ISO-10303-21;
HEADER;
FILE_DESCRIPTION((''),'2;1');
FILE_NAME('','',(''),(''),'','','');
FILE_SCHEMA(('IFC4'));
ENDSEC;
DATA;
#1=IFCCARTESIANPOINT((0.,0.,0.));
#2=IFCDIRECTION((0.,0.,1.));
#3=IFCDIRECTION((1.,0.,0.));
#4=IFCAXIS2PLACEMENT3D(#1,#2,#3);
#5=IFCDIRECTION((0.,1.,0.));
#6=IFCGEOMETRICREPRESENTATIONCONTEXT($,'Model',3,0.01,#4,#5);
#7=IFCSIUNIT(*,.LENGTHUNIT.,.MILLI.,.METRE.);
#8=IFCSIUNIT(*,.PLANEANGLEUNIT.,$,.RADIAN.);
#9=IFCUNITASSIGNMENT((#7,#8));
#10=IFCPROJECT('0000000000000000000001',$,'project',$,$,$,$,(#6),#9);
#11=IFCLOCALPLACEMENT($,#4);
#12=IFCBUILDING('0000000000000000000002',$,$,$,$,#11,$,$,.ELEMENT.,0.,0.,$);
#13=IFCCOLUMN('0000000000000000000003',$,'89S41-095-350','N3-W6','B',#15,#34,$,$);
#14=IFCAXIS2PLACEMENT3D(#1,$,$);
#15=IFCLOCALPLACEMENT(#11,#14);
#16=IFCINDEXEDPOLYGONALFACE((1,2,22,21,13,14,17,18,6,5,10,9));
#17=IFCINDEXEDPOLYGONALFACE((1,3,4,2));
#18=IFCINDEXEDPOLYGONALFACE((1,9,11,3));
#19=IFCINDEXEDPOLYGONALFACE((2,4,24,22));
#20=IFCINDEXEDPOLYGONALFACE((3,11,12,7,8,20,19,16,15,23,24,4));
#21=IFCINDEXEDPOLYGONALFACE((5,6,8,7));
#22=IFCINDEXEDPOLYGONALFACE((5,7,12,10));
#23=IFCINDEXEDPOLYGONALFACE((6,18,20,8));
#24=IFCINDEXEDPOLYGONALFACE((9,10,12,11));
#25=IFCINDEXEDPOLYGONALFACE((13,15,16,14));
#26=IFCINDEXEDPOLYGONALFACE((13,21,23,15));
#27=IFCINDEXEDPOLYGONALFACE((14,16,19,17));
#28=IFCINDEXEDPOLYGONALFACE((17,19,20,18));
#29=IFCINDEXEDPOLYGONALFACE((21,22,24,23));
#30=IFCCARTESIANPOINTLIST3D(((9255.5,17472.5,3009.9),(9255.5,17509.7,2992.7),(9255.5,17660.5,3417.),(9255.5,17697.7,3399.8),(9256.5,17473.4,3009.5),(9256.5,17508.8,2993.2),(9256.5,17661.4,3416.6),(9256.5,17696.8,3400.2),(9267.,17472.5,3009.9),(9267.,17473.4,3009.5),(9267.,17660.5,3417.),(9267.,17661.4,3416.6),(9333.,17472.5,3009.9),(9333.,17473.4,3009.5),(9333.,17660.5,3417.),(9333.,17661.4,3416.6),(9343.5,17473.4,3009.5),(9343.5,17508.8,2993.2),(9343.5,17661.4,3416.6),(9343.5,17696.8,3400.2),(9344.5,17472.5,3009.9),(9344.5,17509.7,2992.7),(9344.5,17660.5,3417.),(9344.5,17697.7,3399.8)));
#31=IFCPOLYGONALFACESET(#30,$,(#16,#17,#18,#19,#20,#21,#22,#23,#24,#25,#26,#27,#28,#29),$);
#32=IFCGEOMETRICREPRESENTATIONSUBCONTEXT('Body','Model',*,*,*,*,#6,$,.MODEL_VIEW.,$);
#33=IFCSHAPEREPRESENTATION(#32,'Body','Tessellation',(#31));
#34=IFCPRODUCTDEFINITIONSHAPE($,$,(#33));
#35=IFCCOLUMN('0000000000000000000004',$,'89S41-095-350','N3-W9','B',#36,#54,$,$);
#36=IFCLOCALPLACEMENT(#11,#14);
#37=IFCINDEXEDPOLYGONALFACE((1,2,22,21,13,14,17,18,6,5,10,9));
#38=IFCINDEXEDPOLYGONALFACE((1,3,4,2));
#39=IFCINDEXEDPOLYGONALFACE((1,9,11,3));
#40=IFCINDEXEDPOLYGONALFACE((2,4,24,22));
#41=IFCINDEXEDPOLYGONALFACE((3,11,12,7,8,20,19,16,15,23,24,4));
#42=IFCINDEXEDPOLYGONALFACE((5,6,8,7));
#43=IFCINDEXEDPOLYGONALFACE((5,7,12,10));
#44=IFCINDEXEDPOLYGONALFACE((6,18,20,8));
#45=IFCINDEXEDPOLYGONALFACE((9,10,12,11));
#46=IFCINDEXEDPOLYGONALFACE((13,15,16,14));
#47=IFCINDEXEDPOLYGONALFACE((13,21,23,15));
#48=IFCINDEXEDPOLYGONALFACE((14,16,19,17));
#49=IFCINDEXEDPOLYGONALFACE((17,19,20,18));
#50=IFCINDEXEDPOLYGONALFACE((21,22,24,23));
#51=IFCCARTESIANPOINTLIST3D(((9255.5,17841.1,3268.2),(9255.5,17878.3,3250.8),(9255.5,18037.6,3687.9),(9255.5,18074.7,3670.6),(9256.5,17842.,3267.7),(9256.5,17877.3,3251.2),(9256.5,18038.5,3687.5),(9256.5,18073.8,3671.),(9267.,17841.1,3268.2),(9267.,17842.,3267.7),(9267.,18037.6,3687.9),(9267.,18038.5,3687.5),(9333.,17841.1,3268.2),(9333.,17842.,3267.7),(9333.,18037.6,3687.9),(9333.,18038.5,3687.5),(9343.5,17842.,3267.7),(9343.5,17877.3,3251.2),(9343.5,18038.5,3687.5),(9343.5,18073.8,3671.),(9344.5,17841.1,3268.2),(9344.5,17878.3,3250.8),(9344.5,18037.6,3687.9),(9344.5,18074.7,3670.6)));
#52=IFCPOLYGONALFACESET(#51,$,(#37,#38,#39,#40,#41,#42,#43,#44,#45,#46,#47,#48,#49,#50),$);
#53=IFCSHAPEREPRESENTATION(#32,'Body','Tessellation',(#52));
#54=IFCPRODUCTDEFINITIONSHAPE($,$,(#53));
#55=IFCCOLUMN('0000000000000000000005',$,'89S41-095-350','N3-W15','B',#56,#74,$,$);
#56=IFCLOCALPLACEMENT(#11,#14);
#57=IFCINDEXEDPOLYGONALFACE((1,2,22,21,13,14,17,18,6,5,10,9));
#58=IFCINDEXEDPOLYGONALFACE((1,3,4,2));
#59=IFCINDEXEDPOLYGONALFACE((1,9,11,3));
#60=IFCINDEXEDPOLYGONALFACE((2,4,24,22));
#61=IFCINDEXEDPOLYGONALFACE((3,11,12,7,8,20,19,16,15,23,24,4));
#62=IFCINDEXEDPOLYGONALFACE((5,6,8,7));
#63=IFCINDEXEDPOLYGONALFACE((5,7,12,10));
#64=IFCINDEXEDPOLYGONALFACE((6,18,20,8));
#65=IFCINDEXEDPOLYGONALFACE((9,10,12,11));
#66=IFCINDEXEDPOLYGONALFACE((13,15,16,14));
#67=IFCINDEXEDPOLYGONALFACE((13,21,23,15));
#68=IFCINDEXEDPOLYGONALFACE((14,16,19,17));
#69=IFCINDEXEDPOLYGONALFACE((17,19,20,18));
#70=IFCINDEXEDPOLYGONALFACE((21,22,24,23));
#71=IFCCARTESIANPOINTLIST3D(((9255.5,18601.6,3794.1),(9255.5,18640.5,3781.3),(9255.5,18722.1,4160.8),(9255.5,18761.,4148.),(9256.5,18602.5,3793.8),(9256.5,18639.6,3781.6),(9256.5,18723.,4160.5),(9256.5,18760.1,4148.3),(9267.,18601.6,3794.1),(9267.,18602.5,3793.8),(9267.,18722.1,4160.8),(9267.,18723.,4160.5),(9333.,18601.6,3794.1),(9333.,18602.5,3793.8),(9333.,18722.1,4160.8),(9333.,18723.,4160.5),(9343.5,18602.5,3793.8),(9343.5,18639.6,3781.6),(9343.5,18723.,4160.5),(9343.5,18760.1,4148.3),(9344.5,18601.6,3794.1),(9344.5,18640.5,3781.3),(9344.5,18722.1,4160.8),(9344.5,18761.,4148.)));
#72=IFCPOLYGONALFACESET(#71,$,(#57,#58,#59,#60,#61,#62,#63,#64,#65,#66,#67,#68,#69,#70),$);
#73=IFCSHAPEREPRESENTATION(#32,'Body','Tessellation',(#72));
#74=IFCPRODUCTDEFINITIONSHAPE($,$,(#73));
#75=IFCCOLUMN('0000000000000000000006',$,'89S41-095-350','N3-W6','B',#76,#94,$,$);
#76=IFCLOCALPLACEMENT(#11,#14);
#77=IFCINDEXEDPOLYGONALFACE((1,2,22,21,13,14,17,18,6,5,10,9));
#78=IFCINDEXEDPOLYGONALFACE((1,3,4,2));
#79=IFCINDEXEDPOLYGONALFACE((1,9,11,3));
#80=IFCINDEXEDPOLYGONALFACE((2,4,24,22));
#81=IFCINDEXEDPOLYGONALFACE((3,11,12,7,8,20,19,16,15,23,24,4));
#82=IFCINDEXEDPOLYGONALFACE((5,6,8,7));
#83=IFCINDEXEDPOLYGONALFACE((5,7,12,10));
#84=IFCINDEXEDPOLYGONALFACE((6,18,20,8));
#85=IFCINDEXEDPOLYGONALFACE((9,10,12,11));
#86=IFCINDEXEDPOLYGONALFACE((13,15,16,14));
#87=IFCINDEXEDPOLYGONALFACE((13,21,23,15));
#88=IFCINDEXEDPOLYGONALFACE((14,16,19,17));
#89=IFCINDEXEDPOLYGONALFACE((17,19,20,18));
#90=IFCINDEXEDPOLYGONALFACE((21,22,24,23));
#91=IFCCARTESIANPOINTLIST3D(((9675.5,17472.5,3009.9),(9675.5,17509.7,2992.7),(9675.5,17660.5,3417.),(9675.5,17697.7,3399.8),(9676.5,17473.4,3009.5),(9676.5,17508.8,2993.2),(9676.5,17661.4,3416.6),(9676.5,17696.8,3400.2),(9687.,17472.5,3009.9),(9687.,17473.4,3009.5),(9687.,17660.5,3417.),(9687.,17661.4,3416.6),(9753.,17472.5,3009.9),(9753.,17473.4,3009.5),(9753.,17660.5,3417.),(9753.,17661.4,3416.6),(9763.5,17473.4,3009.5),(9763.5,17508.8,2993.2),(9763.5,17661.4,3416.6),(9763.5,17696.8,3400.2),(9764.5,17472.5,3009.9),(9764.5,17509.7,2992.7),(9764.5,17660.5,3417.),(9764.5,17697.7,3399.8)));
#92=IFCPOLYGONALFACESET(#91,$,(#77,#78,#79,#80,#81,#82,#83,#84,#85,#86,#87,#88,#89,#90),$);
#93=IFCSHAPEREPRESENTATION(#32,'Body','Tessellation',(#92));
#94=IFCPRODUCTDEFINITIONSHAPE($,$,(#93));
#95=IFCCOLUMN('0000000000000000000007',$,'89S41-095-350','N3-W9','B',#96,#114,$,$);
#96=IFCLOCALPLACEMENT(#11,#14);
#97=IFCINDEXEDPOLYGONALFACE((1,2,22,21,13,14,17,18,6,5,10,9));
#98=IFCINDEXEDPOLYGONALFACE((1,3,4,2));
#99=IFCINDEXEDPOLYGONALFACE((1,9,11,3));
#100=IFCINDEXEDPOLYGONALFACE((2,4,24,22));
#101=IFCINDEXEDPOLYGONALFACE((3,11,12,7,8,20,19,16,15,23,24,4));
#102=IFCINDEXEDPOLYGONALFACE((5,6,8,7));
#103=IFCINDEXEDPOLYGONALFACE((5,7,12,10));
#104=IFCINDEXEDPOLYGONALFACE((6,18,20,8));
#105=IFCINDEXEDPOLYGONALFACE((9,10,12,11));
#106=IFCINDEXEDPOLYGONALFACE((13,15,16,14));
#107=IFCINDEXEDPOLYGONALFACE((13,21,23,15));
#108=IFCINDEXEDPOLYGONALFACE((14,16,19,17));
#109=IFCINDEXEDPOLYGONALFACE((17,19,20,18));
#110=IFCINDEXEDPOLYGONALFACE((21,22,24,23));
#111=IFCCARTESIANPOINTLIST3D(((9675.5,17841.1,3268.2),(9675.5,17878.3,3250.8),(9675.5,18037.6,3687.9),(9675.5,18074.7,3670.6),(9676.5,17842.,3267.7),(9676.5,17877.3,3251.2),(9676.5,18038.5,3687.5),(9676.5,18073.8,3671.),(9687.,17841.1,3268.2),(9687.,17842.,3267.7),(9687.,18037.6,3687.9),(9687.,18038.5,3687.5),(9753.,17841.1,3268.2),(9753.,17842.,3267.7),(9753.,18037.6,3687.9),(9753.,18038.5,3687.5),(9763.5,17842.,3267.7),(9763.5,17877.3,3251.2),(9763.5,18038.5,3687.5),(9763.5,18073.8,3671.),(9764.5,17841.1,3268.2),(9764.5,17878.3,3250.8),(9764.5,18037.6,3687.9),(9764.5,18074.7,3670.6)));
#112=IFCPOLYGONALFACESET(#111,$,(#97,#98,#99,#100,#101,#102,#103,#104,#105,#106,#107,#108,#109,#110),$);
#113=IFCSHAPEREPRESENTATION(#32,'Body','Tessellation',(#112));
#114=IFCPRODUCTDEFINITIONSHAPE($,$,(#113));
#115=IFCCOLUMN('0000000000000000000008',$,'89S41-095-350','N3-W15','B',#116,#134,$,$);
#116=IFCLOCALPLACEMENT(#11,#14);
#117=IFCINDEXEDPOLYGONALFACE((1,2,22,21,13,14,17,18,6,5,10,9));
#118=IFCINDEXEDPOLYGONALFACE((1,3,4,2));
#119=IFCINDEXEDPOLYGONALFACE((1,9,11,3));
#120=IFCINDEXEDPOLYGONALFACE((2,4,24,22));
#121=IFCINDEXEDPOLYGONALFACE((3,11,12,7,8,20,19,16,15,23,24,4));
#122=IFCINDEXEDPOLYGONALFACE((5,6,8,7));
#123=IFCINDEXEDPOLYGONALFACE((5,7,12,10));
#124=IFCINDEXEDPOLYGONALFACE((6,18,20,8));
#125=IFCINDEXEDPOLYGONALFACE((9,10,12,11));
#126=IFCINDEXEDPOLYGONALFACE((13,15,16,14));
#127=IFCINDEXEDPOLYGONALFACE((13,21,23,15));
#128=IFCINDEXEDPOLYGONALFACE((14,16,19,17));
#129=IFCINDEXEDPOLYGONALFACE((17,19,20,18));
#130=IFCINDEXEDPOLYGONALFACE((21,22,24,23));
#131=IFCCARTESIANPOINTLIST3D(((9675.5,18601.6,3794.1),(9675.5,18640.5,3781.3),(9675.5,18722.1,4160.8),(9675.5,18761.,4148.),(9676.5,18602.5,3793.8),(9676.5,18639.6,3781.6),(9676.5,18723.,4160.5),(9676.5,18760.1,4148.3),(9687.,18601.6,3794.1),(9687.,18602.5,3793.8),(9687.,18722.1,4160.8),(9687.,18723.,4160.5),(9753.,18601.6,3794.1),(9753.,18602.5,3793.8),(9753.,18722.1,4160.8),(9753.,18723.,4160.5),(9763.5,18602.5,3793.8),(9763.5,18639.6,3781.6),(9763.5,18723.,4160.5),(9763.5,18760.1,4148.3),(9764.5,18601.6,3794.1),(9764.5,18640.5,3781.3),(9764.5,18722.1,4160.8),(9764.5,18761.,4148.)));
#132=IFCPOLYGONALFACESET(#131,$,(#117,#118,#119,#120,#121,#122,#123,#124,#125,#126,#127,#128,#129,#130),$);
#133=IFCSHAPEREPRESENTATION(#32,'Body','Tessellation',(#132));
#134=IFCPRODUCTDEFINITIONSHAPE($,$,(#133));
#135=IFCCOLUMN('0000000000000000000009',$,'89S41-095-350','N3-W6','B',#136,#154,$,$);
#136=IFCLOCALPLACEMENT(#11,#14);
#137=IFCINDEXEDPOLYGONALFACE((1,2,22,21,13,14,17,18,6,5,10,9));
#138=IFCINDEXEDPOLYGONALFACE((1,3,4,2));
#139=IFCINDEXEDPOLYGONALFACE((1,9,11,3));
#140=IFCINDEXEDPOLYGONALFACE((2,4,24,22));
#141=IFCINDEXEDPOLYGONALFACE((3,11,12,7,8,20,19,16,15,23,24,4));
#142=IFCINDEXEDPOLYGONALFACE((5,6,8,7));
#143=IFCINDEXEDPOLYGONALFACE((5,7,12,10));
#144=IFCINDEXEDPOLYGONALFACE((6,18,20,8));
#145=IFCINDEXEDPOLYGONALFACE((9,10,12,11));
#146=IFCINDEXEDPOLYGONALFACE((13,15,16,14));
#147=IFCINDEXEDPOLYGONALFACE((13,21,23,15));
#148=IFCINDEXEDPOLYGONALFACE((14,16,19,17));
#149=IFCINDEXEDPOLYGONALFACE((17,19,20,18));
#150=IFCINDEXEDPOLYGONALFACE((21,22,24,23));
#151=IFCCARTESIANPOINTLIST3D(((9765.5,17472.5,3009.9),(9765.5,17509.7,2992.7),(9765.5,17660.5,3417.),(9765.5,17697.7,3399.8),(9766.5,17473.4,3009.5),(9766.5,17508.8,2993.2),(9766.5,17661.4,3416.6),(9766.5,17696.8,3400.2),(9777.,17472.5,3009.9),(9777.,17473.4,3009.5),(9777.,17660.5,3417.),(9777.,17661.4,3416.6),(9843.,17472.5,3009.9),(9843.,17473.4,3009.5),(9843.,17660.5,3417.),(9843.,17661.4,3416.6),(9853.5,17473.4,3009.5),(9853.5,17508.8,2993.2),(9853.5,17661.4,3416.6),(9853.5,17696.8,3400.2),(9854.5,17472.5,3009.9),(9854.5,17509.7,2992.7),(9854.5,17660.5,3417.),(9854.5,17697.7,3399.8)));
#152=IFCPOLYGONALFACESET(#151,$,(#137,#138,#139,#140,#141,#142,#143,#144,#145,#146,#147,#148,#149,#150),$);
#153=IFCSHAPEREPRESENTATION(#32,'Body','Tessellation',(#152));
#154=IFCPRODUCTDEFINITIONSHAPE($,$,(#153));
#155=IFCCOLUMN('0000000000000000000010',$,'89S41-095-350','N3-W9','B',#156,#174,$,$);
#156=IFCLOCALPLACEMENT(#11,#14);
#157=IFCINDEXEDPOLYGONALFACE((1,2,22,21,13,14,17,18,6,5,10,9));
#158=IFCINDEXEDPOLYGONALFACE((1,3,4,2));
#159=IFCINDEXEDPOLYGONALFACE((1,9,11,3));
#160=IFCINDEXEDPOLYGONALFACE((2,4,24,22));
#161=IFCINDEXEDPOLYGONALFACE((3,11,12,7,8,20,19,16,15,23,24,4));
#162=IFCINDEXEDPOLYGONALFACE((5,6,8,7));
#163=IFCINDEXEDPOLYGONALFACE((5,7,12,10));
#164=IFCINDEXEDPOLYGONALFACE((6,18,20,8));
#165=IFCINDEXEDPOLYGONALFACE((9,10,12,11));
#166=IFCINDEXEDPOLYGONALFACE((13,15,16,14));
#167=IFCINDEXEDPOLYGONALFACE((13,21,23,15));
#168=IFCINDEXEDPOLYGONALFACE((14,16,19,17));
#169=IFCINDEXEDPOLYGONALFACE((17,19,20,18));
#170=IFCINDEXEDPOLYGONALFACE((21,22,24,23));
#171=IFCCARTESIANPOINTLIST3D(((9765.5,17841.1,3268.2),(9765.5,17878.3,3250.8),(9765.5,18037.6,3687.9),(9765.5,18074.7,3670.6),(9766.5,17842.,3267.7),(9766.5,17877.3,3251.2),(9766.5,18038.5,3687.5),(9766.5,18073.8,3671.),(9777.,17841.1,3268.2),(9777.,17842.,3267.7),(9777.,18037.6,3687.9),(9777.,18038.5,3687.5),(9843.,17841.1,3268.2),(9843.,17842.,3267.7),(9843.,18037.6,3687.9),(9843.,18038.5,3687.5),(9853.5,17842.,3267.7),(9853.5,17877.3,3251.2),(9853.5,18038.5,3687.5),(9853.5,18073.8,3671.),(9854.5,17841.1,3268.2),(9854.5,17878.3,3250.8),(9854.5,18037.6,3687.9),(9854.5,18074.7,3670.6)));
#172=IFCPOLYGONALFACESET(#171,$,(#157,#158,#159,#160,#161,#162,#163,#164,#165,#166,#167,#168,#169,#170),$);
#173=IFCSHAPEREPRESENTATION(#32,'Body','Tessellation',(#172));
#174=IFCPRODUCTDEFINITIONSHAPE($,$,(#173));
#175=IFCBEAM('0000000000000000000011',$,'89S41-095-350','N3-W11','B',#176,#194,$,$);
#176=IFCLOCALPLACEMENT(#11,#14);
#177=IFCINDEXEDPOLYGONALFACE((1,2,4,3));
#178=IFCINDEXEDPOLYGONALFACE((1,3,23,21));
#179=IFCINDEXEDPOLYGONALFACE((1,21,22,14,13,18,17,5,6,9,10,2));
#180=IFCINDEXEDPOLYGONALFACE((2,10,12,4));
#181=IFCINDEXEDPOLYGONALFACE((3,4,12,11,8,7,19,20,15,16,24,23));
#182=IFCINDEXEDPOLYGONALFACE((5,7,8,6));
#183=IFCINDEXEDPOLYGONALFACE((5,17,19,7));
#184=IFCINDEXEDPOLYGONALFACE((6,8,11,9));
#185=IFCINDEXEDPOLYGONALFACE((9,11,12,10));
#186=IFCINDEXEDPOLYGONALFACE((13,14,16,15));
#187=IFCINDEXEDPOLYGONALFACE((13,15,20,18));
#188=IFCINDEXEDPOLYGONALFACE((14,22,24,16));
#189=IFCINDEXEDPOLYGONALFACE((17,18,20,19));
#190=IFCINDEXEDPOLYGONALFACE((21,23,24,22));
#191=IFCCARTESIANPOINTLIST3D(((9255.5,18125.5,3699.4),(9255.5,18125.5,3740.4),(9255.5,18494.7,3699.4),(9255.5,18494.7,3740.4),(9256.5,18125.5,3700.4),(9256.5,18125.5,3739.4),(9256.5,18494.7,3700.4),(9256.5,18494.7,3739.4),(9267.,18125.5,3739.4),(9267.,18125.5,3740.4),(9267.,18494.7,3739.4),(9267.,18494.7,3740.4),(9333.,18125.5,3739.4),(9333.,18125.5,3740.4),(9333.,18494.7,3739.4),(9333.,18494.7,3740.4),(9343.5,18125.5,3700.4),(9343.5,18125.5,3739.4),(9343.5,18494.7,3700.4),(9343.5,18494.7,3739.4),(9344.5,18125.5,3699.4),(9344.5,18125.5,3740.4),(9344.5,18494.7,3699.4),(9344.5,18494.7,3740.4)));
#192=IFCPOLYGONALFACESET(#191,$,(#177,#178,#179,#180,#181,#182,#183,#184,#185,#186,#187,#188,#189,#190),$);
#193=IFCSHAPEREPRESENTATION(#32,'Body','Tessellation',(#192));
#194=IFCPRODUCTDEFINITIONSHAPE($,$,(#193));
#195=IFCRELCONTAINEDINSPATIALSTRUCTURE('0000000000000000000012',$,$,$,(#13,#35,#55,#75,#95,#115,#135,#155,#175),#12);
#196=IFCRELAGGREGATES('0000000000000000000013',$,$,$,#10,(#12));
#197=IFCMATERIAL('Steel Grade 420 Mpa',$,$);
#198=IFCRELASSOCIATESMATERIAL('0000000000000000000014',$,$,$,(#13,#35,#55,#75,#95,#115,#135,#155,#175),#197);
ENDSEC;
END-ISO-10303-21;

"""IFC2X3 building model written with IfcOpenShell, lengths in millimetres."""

from ifc_helpers import new_model, si_unit, direction, frame, origin, origin_with_axes, origin_2d_with_axis, place, context, subcontext, project, spatial, c_section, extrude, source, transform, mapped, material, element, save


model = new_model("IFC2X3")

# Units and contexts
model_context = context("Model", 3, precision=0.01, world=origin_with_axes(), true_north=direction((0.0, 1.0, 0.0)))
body_context = subcontext(model_context, "Body", "Model", "MODEL_VIEW")
ifc_project = project(units=[si_unit("LENGTHUNIT", "METRE", prefix="MILLI"), si_unit("PLANEANGLEUNIT", "RADIAN")], contexts=[model_context])

# Building
building_placement = place(None, origin_with_axes())
building = spatial("IfcBuilding", under=ifc_project, at=building_placement, CompositionType="ELEMENT", ElevationOfRefHeight=0.0, ElevationOfTerrain=0.0)

# Columns
ifc_material = material(Name="Steel Grade 420 Mpa")
shared_shape_1 = source(origin(), body_context, "Body", "SweptSolid", [
    extrude(c_section(Depth=89.0, Width=41.0, WallThickness=1.0, Girth=11.5, at=origin_2d_with_axis()), origin_with_axes(), (0.0, 0.0, 1.0), 448.4),
])
column_1_placement = place(None, frame((9300.0, 17679.1, 3408.4), z_axis=(0.0, -0.419234, -0.907878), x_axis=(0.0, -0.907878, 0.419234)))
element("IfcColumn", 1, at=column_1_placement, inside=building, material=ifc_material, Name="89S41-095-350", Description="N3-W6", ObjectType="B", context=body_context, shape_type="MappedRepresentation", body=[
    mapped(shared_shape_1, transform((0.0, 0.0, 0.0), scale=1.0)),
])
shared_shape_2 = source(origin(), body_context, "Body", "SweptSolid", [
    extrude(c_section(Depth=89.0, Width=41.0, WallThickness=1.0, Girth=11.5, at=origin_2d_with_axis()), origin_with_axes(), (0.0, 0.0, 1.0), 463.5),
])
column_2_placement = place(None, frame((9300.0, 18056.1, 3679.2), z_axis=(0.0, -0.423875, -0.905721), x_axis=(0.0, -0.905721, 0.423875)))
element("IfcColumn", 2, at=column_2_placement, inside=building, material=ifc_material, Name="89S41-095-350", Description="N3-W9", ObjectType="B", context=body_context, shape_type="MappedRepresentation", body=[
    mapped(shared_shape_2, transform((0.0, 0.0, 0.0), scale=1.0)),
])
shared_shape_3 = source(origin(), body_context, "Body", "SweptSolid", [
    extrude(c_section(Depth=89.0, Width=41.0, WallThickness=1.0, Girth=11.5, at=origin_2d_with_axis()), origin_with_axes(), (0.0, 0.0, 1.0), 385.9),
])
column_3_placement = place(None, frame((9300.0, 18741.5, 4154.4), z_axis=(0.0, -0.312196, -0.950018), x_axis=(0.0, -0.950018, 0.312196)))
element("IfcColumn", 3, at=column_3_placement, inside=building, material=ifc_material, Name="89S41-095-350", Description="N3-W15", ObjectType="B", context=body_context, shape_type="MappedRepresentation", body=[
    mapped(shared_shape_3, transform((0.0, 0.0, 0.0), scale=1.0)),
])
shared_shape_4 = source(origin(), body_context, "Body", "SweptSolid", [
    extrude(c_section(Depth=89.0, Width=41.0, WallThickness=1.0, Girth=11.5, at=origin_2d_with_axis()), origin_with_axes(), (0.0, 0.0, 1.0), 448.4),
])
column_4_placement = place(None, frame((9720.0, 17679.1, 3408.4), z_axis=(0.0, -0.419234, -0.907878), x_axis=(0.0, -0.907878, 0.419234)))
element("IfcColumn", 4, at=column_4_placement, inside=building, material=ifc_material, Name="89S41-095-350", Description="N3-W6", ObjectType="B", context=body_context, shape_type="MappedRepresentation", body=[
    mapped(shared_shape_4, transform((0.0, 0.0, 0.0), scale=1.0)),
])
shared_shape_5 = source(origin(), body_context, "Body", "SweptSolid", [
    extrude(c_section(Depth=89.0, Width=41.0, WallThickness=1.0, Girth=11.5, at=origin_2d_with_axis()), origin_with_axes(), (0.0, 0.0, 1.0), 463.5),
])
column_5_placement = place(None, frame((9720.0, 18056.1, 3679.2), z_axis=(0.0, -0.423875, -0.905721), x_axis=(0.0, -0.905721, 0.423875)))
element("IfcColumn", 5, at=column_5_placement, inside=building, material=ifc_material, Name="89S41-095-350", Description="N3-W9", ObjectType="B", context=body_context, shape_type="MappedRepresentation", body=[
    mapped(shared_shape_5, transform((0.0, 0.0, 0.0), scale=1.0)),
])
shared_shape_6 = source(origin(), body_context, "Body", "SweptSolid", [
    extrude(c_section(Depth=89.0, Width=41.0, WallThickness=1.0, Girth=11.5, at=origin_2d_with_axis()), origin_with_axes(), (0.0, 0.0, 1.0), 385.9),
])
column_6_placement = place(None, frame((9720.0, 18741.5, 4154.4), z_axis=(0.0, -0.312196, -0.950018), x_axis=(0.0, -0.950018, 0.312196)))
element("IfcColumn", 6, at=column_6_placement, inside=building, material=ifc_material, Name="89S41-095-350", Description="N3-W15", ObjectType="B", context=body_context, shape_type="MappedRepresentation", body=[
    mapped(shared_shape_6, transform((0.0, 0.0, 0.0), scale=1.0)),
])
shared_shape_7 = source(origin(), body_context, "Body", "SweptSolid", [
    extrude(c_section(Depth=89.0, Width=41.0, WallThickness=1.0, Girth=11.5, at=origin_2d_with_axis()), origin_with_axes(), (0.0, 0.0, 1.0), 448.4),
])
column_7_placement = place(None, frame((9810.0, 17679.1, 3408.4), z_axis=(0.0, -0.419234, -0.907878), x_axis=(0.0, -0.907878, 0.419234)))
element("IfcColumn", 7, at=column_7_placement, inside=building, material=ifc_material, Name="89S41-095-350", Description="N3-W6", ObjectType="B", context=body_context, shape_type="MappedRepresentation", body=[
    mapped(shared_shape_7, transform((0.0, 0.0, 0.0), scale=1.0)),
])
shared_shape_8 = source(origin(), body_context, "Body", "SweptSolid", [
    extrude(c_section(Depth=89.0, Width=41.0, WallThickness=1.0, Girth=11.5, at=origin_2d_with_axis()), origin_with_axes(), (0.0, 0.0, 1.0), 463.5),
])
column_8_placement = place(None, frame((9810.0, 18056.1, 3679.2), z_axis=(0.0, -0.423875, -0.905721), x_axis=(0.0, -0.905721, 0.423875)))
element("IfcColumn", 8, at=column_8_placement, inside=building, material=ifc_material, Name="89S41-095-350", Description="N3-W9", ObjectType="B", context=body_context, shape_type="MappedRepresentation", body=[
    mapped(shared_shape_8, transform((0.0, 0.0, 0.0), scale=1.0)),
])

# Beam
shared_shape_9 = source(origin(), body_context, "Body", "SweptSolid", [
    extrude(c_section(Depth=89.0, Width=41.0, WallThickness=1.0, Girth=11.5, at=origin_2d_with_axis()), origin_with_axes(), (0.0, 0.0, 1.0), 369.2),
])
beam_1_placement = place(None, frame((9300.0, 18494.7, 3719.9), z_axis=(0.0, -1.0, 0.0), x_axis=(0.0, 0.0, 1.0)))
element("IfcBeam", 9, at=beam_1_placement, inside=building, material=ifc_material, Name="89S41-095-350", Description="N3-W11", ObjectType="B", context=body_context, shape_type="MappedRepresentation", body=[
    mapped(shared_shape_9, transform((0.0, 0.0, 0.0), scale=1.0)),
])

save(model, "model.ifc")
